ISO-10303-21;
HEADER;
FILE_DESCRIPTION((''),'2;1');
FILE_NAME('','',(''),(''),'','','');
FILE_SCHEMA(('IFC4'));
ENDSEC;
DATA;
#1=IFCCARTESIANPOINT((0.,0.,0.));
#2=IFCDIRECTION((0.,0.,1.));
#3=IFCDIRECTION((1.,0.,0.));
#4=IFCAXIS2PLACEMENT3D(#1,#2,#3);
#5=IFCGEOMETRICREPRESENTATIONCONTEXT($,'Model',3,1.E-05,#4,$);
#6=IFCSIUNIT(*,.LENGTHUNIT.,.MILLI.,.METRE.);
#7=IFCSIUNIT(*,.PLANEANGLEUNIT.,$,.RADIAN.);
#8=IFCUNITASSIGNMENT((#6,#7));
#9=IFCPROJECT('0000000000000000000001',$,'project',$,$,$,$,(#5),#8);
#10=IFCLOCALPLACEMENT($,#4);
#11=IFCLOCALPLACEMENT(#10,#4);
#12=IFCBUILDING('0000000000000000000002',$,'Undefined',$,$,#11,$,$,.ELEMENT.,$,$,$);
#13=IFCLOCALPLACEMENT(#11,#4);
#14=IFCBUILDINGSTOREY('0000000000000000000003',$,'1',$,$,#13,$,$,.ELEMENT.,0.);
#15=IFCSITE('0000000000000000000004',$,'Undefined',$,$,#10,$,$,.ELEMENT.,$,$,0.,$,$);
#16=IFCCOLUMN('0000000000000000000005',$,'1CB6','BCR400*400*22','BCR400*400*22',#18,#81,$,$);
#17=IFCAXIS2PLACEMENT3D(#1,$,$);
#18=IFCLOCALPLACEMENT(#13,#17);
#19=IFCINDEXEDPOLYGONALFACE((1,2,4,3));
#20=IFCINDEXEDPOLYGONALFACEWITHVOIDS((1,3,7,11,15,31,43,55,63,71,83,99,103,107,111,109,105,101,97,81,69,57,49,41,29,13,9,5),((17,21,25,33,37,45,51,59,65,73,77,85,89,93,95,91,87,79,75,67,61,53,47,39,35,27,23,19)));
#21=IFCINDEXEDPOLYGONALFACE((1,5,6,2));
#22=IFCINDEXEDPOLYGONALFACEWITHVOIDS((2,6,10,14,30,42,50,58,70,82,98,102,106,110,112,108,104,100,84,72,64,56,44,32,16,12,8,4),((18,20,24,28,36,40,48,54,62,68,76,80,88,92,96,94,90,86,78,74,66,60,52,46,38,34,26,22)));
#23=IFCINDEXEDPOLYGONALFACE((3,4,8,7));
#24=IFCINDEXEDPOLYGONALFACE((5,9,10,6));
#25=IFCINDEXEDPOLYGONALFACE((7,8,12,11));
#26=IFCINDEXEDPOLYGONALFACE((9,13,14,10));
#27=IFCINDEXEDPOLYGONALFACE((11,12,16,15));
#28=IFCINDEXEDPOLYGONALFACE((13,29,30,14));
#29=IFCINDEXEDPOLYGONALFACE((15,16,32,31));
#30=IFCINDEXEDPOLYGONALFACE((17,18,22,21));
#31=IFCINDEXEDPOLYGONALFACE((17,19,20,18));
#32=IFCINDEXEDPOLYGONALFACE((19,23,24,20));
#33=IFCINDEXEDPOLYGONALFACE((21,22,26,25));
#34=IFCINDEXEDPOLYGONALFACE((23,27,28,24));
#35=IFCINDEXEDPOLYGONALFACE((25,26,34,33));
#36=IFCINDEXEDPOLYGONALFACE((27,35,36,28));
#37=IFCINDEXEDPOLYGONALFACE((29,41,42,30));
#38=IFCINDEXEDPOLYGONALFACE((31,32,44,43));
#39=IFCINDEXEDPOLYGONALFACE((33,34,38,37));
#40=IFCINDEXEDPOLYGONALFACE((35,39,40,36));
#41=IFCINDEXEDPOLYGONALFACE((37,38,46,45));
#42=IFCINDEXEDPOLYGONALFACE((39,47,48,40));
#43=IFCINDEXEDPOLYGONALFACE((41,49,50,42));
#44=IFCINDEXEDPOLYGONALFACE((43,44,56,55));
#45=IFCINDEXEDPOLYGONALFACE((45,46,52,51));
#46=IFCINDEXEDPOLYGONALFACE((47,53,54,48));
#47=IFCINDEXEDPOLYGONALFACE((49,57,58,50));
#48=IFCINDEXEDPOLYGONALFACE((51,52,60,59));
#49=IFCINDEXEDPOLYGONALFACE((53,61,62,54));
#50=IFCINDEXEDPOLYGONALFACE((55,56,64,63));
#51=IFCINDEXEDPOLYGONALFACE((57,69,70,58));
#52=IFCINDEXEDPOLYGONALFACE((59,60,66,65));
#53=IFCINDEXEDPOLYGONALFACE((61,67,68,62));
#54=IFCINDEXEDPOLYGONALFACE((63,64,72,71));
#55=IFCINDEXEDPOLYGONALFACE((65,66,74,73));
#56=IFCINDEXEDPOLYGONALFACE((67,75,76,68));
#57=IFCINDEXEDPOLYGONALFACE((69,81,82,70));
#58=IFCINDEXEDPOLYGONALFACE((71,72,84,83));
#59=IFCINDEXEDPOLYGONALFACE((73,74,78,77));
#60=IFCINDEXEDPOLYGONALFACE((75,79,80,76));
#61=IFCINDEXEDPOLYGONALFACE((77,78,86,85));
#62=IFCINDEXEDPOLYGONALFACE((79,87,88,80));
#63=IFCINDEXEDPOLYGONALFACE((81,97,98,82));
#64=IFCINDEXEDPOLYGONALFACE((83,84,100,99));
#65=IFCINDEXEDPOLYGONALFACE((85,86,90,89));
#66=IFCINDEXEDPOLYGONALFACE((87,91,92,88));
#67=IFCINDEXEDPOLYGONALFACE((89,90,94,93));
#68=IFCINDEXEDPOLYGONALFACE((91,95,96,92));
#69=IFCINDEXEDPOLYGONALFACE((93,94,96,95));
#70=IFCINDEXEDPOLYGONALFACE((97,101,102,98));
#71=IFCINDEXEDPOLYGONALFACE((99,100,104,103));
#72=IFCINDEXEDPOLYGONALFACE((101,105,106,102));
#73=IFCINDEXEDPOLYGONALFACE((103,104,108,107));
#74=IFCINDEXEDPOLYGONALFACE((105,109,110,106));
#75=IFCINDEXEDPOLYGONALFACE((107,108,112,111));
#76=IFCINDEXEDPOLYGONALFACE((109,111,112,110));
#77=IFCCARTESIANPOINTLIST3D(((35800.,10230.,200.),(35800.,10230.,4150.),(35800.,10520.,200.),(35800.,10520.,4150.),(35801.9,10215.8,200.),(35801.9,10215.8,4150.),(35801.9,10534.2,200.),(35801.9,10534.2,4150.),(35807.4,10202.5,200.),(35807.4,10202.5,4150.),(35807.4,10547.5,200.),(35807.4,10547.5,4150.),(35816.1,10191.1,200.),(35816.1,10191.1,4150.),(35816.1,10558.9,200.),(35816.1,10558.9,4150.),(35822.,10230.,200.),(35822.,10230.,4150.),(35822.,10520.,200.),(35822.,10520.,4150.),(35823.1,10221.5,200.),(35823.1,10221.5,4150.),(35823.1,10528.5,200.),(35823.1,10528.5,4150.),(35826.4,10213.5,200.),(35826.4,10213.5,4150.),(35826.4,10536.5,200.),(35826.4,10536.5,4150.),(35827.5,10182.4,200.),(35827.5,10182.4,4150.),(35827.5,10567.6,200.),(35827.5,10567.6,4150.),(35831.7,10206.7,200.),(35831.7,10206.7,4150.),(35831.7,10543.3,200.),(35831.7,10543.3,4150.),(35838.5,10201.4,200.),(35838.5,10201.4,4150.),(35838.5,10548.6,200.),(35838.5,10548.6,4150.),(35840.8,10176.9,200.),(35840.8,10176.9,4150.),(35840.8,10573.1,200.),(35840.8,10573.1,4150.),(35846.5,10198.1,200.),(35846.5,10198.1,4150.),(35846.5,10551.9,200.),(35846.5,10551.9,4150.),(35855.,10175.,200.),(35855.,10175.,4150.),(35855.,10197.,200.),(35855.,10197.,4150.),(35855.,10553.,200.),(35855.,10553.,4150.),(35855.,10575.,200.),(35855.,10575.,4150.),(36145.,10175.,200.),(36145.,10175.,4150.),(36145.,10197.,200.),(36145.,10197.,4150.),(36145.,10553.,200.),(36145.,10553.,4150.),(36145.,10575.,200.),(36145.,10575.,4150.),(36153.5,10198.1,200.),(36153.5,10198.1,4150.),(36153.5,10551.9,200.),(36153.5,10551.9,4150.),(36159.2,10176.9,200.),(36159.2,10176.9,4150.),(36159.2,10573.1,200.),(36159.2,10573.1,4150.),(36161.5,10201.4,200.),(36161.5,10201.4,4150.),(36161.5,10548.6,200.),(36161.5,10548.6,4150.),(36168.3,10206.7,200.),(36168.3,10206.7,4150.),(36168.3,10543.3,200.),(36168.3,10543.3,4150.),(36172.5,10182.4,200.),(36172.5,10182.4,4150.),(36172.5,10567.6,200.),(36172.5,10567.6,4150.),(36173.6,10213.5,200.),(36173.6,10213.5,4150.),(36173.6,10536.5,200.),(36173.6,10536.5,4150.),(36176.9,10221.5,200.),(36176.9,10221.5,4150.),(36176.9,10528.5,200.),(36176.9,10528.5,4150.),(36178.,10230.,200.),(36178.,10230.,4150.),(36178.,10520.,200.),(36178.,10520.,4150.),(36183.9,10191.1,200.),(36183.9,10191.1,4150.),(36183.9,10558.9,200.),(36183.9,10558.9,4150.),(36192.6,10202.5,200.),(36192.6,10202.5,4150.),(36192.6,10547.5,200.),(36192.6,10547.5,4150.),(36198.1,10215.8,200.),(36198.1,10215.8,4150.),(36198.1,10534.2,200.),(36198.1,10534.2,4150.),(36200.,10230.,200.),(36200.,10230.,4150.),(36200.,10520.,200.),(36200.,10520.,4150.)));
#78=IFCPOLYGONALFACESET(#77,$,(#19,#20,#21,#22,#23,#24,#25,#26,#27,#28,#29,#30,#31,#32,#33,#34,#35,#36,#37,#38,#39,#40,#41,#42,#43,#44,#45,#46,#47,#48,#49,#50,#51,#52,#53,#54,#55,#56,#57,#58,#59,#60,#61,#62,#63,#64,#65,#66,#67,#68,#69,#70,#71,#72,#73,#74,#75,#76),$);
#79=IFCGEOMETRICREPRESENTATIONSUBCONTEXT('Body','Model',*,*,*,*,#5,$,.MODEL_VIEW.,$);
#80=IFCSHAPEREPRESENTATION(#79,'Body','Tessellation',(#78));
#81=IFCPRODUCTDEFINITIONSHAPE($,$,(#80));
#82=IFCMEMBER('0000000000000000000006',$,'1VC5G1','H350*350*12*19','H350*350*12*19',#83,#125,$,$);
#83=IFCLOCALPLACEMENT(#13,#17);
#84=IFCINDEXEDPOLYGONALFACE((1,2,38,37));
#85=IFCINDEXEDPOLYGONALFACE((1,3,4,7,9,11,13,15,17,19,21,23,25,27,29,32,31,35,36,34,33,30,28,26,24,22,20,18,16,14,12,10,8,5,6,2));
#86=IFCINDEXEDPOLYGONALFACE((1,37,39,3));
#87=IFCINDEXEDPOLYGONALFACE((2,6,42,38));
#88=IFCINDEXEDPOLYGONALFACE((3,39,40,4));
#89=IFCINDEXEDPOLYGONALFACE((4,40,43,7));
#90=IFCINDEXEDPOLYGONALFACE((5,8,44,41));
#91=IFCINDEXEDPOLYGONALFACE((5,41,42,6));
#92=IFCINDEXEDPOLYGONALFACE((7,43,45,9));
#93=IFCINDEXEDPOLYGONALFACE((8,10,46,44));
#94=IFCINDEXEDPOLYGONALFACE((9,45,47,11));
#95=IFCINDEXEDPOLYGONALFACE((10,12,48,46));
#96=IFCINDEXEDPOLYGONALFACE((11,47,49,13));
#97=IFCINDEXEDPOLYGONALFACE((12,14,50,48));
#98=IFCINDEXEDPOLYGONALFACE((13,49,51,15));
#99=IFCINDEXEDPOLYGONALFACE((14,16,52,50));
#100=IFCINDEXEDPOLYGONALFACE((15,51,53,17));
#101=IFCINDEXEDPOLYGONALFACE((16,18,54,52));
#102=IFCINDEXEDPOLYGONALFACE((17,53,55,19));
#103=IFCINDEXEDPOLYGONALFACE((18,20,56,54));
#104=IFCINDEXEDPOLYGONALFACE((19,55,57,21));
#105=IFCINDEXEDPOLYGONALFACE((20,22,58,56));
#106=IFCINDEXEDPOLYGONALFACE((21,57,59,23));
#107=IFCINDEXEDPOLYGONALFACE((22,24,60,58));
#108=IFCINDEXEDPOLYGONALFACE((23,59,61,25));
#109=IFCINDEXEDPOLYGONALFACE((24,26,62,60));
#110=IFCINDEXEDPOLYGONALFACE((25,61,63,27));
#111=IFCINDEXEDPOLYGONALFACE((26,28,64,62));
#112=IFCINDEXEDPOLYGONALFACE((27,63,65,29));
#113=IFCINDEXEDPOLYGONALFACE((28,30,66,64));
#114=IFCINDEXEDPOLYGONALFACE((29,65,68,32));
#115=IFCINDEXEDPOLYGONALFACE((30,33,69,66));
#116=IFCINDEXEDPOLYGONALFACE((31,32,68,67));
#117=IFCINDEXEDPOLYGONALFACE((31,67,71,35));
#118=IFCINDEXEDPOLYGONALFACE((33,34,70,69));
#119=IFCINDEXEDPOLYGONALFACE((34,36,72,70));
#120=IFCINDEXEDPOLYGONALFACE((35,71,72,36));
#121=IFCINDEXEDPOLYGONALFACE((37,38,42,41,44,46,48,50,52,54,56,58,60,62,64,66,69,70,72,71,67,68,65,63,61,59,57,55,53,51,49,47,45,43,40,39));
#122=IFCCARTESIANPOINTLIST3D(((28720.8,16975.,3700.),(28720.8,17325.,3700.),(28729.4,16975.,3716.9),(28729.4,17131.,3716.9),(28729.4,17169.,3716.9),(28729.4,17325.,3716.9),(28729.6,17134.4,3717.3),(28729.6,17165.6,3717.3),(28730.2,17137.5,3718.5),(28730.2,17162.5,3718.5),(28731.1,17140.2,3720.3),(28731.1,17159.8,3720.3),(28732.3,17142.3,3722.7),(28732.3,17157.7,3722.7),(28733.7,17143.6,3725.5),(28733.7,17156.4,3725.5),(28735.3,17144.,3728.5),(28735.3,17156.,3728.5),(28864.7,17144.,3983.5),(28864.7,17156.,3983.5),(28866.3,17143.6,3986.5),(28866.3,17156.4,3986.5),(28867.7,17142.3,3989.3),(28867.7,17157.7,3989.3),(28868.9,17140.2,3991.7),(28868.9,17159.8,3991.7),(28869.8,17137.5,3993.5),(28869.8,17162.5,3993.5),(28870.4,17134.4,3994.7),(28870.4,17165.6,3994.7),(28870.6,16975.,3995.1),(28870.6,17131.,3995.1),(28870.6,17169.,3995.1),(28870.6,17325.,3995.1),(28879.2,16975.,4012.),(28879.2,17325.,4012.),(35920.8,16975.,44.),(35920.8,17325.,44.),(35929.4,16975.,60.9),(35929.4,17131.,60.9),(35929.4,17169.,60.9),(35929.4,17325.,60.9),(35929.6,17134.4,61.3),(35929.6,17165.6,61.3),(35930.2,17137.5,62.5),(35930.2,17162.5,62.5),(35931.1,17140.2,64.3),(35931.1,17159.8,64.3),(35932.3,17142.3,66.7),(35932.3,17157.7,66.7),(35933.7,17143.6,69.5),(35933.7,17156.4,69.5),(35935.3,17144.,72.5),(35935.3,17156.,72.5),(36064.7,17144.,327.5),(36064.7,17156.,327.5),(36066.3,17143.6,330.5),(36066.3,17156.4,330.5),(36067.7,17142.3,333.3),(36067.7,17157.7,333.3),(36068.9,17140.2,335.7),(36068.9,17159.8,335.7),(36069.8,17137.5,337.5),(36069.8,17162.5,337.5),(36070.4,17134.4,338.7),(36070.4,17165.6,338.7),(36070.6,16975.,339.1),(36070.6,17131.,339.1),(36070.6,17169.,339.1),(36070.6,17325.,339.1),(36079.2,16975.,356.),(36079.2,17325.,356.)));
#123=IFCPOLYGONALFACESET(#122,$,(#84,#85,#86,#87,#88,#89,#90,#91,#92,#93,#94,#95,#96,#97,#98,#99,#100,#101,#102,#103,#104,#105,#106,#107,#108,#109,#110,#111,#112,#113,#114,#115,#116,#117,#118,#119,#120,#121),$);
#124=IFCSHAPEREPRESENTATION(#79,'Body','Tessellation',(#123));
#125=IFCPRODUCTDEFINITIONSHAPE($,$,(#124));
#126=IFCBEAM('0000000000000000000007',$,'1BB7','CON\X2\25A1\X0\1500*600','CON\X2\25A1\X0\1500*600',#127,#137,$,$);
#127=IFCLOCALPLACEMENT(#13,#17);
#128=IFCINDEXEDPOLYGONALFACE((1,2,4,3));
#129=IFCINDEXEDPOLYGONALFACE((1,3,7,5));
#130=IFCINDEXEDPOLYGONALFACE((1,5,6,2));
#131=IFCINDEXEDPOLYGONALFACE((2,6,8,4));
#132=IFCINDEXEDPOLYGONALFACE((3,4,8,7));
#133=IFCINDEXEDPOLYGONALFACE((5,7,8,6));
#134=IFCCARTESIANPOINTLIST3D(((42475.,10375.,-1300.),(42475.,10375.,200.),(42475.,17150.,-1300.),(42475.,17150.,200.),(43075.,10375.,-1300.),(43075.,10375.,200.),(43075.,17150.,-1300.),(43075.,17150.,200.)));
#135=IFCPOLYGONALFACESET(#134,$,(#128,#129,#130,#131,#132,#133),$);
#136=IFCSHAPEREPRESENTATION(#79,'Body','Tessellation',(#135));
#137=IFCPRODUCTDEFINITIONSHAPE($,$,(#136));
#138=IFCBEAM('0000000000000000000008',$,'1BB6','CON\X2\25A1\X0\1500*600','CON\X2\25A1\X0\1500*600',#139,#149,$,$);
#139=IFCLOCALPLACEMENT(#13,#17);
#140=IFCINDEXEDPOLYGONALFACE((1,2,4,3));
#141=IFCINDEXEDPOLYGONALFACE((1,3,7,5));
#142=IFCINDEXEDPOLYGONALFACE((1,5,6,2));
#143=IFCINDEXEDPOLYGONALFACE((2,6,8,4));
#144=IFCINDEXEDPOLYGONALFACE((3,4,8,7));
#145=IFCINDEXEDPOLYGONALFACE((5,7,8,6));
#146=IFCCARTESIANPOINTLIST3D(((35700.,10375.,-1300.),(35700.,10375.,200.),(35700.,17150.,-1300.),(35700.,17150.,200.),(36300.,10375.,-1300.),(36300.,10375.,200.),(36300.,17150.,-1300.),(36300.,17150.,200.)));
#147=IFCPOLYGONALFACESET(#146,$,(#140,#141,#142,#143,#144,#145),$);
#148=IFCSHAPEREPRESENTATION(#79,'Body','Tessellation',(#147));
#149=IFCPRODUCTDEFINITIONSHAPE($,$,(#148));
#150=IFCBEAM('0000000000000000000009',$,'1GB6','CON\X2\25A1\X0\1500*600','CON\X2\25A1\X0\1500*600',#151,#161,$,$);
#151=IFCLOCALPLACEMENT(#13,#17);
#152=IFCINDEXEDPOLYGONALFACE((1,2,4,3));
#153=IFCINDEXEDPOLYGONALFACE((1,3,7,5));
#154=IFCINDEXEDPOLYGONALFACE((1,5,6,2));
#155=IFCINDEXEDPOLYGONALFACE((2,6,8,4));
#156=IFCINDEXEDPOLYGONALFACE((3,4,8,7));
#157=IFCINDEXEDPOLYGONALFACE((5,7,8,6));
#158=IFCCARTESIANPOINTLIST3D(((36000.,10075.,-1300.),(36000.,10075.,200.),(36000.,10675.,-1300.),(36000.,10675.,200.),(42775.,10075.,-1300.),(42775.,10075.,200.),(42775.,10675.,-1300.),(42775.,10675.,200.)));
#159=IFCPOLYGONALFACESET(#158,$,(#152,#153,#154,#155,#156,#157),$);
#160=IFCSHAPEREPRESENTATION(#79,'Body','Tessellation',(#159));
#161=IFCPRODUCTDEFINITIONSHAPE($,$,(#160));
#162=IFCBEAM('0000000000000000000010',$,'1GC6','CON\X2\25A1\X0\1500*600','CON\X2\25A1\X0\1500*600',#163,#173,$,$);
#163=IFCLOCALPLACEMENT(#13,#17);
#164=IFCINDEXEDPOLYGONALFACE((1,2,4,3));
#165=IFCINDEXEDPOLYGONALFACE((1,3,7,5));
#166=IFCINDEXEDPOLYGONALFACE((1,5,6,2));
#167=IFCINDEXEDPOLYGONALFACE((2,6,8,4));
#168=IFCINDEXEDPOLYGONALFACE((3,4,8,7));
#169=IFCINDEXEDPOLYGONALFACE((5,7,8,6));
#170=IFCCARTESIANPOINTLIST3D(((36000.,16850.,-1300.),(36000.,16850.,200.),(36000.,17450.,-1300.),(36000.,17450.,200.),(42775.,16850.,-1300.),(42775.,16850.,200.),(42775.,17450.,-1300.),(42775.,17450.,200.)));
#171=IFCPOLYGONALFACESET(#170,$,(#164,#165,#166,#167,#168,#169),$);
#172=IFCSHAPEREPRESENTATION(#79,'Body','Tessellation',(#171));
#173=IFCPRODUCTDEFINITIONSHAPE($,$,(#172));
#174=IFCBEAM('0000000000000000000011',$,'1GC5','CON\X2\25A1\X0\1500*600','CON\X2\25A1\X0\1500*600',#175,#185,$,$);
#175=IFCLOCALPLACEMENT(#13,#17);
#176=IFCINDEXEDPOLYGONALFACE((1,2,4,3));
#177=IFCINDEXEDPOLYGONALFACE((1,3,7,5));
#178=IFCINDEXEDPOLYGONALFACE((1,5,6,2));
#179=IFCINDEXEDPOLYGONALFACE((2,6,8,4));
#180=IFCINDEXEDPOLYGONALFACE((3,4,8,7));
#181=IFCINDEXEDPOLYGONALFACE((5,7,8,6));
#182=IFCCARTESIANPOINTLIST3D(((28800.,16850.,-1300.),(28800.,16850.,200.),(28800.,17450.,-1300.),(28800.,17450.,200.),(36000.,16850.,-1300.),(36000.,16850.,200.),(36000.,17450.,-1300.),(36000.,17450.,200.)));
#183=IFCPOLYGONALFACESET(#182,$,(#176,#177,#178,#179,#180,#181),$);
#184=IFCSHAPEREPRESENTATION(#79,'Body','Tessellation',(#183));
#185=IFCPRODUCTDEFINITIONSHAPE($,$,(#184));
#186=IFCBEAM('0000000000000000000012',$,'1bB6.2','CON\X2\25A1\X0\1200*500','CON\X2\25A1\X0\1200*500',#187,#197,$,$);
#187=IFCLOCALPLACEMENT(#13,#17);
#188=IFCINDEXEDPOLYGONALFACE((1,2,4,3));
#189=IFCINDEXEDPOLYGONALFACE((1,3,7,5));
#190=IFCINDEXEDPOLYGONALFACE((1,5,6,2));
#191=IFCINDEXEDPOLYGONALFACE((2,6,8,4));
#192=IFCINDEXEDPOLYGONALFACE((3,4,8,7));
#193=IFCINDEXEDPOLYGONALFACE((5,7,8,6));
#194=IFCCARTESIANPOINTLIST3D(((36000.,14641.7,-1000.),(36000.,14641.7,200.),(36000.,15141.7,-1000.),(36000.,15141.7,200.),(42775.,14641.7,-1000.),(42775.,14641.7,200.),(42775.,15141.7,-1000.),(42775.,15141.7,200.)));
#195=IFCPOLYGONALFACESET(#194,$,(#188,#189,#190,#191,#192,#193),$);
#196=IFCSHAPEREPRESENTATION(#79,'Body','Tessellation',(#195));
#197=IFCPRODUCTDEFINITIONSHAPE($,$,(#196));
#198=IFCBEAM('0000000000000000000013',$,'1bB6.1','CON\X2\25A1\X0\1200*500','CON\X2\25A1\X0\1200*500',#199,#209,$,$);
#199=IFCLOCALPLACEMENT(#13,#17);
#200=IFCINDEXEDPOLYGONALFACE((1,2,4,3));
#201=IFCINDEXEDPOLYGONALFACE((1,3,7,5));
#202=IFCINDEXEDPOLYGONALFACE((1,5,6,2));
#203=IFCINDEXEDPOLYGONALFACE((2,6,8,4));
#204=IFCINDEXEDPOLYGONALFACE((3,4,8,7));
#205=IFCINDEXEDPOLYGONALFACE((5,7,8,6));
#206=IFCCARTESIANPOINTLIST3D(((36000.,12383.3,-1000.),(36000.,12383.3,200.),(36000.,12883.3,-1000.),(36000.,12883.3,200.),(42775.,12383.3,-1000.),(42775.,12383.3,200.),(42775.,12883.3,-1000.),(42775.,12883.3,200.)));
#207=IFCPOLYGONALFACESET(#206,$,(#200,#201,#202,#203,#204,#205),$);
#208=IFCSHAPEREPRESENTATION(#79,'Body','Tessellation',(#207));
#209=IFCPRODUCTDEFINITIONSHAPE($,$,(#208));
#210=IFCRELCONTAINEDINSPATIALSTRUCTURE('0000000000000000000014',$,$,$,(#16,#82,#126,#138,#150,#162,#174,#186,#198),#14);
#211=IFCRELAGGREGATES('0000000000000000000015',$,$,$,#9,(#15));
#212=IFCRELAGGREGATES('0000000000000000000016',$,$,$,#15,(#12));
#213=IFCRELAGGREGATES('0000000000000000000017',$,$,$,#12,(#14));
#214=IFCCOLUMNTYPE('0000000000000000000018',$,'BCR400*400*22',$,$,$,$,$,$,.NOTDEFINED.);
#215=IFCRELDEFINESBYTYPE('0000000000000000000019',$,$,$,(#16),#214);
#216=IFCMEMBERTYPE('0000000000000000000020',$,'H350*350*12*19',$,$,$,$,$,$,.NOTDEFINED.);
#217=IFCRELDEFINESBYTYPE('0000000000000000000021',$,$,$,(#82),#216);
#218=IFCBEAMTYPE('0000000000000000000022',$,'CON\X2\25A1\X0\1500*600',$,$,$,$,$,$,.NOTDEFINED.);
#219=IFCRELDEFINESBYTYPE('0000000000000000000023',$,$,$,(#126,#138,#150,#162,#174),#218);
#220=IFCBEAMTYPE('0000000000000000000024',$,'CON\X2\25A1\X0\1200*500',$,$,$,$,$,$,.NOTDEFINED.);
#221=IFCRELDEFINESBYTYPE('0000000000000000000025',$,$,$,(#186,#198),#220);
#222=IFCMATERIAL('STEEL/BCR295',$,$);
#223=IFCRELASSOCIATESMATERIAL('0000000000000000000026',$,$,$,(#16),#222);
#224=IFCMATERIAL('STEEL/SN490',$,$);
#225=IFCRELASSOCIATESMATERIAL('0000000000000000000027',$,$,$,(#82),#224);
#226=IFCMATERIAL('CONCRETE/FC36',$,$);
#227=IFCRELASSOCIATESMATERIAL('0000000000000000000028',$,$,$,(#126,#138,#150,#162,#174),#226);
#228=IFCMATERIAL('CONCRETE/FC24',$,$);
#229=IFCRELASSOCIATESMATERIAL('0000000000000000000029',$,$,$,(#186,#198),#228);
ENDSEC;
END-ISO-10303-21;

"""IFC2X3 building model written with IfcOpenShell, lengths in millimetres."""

from ifc_helpers import new_model, si_unit, frame, origin_with_axes, origin_2d_with_axis, place, context, subcontext, project, spatial, rectangle, hollow_rectangle, i_section, extrude, material, type_object, element, save


model = new_model("IFC2X3")

# Units and contexts
model_context = context("Model", 3, precision=1e-05, world=origin_with_axes())
body_context = subcontext(model_context, "Body", "Model", "MODEL_VIEW")
ifc_project = project(units=[si_unit("LENGTHUNIT", "METRE", prefix="MILLI"), si_unit("PLANEANGLEUNIT", "RADIAN")], contexts=[model_context])

# Site, building, storey
site_placement = place(None, origin_with_axes())
site = spatial("IfcSite", under=ifc_project, at=site_placement, Name="Undefined", CompositionType="ELEMENT", RefElevation=0.0)
building_placement = place(site_placement, origin_with_axes())
building = spatial("IfcBuilding", under=site, at=building_placement, Name="Undefined", CompositionType="ELEMENT")
storey_placement = place(building_placement, origin_with_axes())
storey = spatial("IfcBuildingStorey", under=building, at=storey_placement, Name="1", CompositionType="ELEMENT", Elevation=0.0)

# Shared definitions
ifc_material_1 = material(Name="CONCRETE/FC24")

# Column
ifc_material_2 = material(Name="STEEL/SN490")
ifc_material_3 = material(Name="STEEL/BCR295")
column_type_1 = type_object("IfcColumnType", Name="BCR400*400*22", PredefinedType="NOTDEFINED")
for number, where, z_axis, x_axis, name in (
    (1, (36000.0, 10375.0, 200.0), (0.0, 0.0, 1.0), (0.0, 1.0, 0.0), "1CB6"),
):
    element("IfcColumn", number, at=place(storey_placement, frame(where, z_axis=z_axis, x_axis=x_axis)), inside=storey, type_object=column_type_1, material=ifc_material_3, Name=name, Description="BCR400*400*22", ObjectType="BCR400*400*22", context=body_context, shape_type="SweptSolid", body=[
        extrude(hollow_rectangle(XDim=400.0, YDim=400.0, WallThickness=22.0, InnerFilletRadius=33.0, OuterFilletRadius=55.0, at=origin_2d_with_axis()), frame((0.0, 0.0, 3950.0), z_axis=(0.0, 0.0, -1.0), x_axis=(0.0, 1.0, 0.0)), (0.0, 0.0, 1.0), 3950.0),
    ])

# Member
member_type = type_object("IfcMemberType", Name="H350*350*12*19", PredefinedType="NOTDEFINED")
member_placement = place(storey_placement, frame((36000.0, 17150.0, 200.0), z_axis=(0.452753, 0.0, 0.891636), x_axis=(-0.891636, 0.0, 0.452753)))
element("IfcMember", 2, at=member_placement, inside=storey, type_object=member_type, material=ifc_material_2, Name="1VC5G1", Description="H350*350*12*19", ObjectType="H350*350*12*19", context=body_context, shape_type="SweptSolid", body=[
    extrude(i_section(OverallWidth=350.0, OverallDepth=350.0, WebThickness=12.0, FlangeThickness=19.0, FilletRadius=13.0, at=origin_2d_with_axis()), frame((8075.0, 0.0, 0.0), z_axis=(-1.0, 0.0, 0.0), x_axis=(0.0, -1.0, 0.0)), (0.0, 0.0, 1.0), 8075.0),
])

# Beams
ifc_material_4 = material(Name="CONCRETE/FC36")
beam_type_1 = type_object("IfcBeamType", Name="CON□1500*600", PredefinedType="NOTDEFINED")
for number, where, z_axis, x_axis, name in (
    (3, (42775.0, 10375.0, -550.0), (0.0, 0.0, 1.0), (0.0, 1.0, 0.0), "1BB7"),
    (4, (36000.0, 10375.0, -550.0), (0.0, 0.0, 1.0), (0.0, 1.0, 0.0), "1BB6"),
    (5, (36000.0, 10375.0, -550.0), (0.0, 0.0, 1.0), (1.0, 0.0, 0.0), "1GB6"),
    (6, (36000.0, 17150.0, -550.0), (0.0, 0.0, 1.0), (1.0, 0.0, 0.0), "1GC6"),
):
    element("IfcBeam", number, at=place(storey_placement, frame(where, z_axis=z_axis, x_axis=x_axis)), inside=storey, type_object=beam_type_1, material=ifc_material_4, Name=name, Description="CON□1500*600", ObjectType="CON□1500*600", context=body_context, shape_type="SweptSolid", body=[
        extrude(rectangle(XDim=600.0, YDim=1500.0, at=origin_2d_with_axis()), frame((6775.0, 0.0, 0.0), z_axis=(-1.0, 0.0, 0.0), x_axis=(0.0, -1.0, 0.0)), (0.0, 0.0, 1.0), 6775.0),
    ])
beam_placement = place(storey_placement, frame((28800.0, 17150.0, -550.0), z_axis=(0.0, 0.0, 1.0), x_axis=(1.0, 0.0, 0.0)))
element("IfcBeam", 7, at=beam_placement, inside=storey, type_object=beam_type_1, material=ifc_material_4, Name="1GC5", Description="CON□1500*600", ObjectType="CON□1500*600", context=body_context, shape_type="SweptSolid", body=[
    extrude(rectangle(XDim=600.0, YDim=1500.0, at=origin_2d_with_axis()), frame((7200.0, 0.0, 0.0), z_axis=(-1.0, 0.0, 0.0), x_axis=(0.0, -1.0, 0.0)), (0.0, 0.0, 1.0), 7200.0),
])
beam_type_2 = type_object("IfcBeamType", Name="CON□1200*500", PredefinedType="NOTDEFINED")
for number, where, z_axis, x_axis, name in (
    (8, (36000.0, 14891.7, -400.0), (0.0, 0.0, 1.0), (1.0, 0.0, 0.0), "1bB6.2"),
    (9, (36000.0, 12633.3, -400.0), (0.0, 0.0, 1.0), (1.0, 0.0, 0.0), "1bB6.1"),
):
    element("IfcBeam", number, at=place(storey_placement, frame(where, z_axis=z_axis, x_axis=x_axis)), inside=storey, type_object=beam_type_2, material=ifc_material_1, Name=name, Description="CON□1200*500", ObjectType="CON□1200*500", context=body_context, shape_type="SweptSolid", body=[
        extrude(rectangle(XDim=500.0, YDim=1200.0, at=origin_2d_with_axis()), frame((6775.0, 0.0, 0.0), z_axis=(-1.0, 0.0, 0.0), x_axis=(0.0, -1.0, 0.0)), (0.0, 0.0, 1.0), 6775.0),
    ])

save(model, "model.ifc")
